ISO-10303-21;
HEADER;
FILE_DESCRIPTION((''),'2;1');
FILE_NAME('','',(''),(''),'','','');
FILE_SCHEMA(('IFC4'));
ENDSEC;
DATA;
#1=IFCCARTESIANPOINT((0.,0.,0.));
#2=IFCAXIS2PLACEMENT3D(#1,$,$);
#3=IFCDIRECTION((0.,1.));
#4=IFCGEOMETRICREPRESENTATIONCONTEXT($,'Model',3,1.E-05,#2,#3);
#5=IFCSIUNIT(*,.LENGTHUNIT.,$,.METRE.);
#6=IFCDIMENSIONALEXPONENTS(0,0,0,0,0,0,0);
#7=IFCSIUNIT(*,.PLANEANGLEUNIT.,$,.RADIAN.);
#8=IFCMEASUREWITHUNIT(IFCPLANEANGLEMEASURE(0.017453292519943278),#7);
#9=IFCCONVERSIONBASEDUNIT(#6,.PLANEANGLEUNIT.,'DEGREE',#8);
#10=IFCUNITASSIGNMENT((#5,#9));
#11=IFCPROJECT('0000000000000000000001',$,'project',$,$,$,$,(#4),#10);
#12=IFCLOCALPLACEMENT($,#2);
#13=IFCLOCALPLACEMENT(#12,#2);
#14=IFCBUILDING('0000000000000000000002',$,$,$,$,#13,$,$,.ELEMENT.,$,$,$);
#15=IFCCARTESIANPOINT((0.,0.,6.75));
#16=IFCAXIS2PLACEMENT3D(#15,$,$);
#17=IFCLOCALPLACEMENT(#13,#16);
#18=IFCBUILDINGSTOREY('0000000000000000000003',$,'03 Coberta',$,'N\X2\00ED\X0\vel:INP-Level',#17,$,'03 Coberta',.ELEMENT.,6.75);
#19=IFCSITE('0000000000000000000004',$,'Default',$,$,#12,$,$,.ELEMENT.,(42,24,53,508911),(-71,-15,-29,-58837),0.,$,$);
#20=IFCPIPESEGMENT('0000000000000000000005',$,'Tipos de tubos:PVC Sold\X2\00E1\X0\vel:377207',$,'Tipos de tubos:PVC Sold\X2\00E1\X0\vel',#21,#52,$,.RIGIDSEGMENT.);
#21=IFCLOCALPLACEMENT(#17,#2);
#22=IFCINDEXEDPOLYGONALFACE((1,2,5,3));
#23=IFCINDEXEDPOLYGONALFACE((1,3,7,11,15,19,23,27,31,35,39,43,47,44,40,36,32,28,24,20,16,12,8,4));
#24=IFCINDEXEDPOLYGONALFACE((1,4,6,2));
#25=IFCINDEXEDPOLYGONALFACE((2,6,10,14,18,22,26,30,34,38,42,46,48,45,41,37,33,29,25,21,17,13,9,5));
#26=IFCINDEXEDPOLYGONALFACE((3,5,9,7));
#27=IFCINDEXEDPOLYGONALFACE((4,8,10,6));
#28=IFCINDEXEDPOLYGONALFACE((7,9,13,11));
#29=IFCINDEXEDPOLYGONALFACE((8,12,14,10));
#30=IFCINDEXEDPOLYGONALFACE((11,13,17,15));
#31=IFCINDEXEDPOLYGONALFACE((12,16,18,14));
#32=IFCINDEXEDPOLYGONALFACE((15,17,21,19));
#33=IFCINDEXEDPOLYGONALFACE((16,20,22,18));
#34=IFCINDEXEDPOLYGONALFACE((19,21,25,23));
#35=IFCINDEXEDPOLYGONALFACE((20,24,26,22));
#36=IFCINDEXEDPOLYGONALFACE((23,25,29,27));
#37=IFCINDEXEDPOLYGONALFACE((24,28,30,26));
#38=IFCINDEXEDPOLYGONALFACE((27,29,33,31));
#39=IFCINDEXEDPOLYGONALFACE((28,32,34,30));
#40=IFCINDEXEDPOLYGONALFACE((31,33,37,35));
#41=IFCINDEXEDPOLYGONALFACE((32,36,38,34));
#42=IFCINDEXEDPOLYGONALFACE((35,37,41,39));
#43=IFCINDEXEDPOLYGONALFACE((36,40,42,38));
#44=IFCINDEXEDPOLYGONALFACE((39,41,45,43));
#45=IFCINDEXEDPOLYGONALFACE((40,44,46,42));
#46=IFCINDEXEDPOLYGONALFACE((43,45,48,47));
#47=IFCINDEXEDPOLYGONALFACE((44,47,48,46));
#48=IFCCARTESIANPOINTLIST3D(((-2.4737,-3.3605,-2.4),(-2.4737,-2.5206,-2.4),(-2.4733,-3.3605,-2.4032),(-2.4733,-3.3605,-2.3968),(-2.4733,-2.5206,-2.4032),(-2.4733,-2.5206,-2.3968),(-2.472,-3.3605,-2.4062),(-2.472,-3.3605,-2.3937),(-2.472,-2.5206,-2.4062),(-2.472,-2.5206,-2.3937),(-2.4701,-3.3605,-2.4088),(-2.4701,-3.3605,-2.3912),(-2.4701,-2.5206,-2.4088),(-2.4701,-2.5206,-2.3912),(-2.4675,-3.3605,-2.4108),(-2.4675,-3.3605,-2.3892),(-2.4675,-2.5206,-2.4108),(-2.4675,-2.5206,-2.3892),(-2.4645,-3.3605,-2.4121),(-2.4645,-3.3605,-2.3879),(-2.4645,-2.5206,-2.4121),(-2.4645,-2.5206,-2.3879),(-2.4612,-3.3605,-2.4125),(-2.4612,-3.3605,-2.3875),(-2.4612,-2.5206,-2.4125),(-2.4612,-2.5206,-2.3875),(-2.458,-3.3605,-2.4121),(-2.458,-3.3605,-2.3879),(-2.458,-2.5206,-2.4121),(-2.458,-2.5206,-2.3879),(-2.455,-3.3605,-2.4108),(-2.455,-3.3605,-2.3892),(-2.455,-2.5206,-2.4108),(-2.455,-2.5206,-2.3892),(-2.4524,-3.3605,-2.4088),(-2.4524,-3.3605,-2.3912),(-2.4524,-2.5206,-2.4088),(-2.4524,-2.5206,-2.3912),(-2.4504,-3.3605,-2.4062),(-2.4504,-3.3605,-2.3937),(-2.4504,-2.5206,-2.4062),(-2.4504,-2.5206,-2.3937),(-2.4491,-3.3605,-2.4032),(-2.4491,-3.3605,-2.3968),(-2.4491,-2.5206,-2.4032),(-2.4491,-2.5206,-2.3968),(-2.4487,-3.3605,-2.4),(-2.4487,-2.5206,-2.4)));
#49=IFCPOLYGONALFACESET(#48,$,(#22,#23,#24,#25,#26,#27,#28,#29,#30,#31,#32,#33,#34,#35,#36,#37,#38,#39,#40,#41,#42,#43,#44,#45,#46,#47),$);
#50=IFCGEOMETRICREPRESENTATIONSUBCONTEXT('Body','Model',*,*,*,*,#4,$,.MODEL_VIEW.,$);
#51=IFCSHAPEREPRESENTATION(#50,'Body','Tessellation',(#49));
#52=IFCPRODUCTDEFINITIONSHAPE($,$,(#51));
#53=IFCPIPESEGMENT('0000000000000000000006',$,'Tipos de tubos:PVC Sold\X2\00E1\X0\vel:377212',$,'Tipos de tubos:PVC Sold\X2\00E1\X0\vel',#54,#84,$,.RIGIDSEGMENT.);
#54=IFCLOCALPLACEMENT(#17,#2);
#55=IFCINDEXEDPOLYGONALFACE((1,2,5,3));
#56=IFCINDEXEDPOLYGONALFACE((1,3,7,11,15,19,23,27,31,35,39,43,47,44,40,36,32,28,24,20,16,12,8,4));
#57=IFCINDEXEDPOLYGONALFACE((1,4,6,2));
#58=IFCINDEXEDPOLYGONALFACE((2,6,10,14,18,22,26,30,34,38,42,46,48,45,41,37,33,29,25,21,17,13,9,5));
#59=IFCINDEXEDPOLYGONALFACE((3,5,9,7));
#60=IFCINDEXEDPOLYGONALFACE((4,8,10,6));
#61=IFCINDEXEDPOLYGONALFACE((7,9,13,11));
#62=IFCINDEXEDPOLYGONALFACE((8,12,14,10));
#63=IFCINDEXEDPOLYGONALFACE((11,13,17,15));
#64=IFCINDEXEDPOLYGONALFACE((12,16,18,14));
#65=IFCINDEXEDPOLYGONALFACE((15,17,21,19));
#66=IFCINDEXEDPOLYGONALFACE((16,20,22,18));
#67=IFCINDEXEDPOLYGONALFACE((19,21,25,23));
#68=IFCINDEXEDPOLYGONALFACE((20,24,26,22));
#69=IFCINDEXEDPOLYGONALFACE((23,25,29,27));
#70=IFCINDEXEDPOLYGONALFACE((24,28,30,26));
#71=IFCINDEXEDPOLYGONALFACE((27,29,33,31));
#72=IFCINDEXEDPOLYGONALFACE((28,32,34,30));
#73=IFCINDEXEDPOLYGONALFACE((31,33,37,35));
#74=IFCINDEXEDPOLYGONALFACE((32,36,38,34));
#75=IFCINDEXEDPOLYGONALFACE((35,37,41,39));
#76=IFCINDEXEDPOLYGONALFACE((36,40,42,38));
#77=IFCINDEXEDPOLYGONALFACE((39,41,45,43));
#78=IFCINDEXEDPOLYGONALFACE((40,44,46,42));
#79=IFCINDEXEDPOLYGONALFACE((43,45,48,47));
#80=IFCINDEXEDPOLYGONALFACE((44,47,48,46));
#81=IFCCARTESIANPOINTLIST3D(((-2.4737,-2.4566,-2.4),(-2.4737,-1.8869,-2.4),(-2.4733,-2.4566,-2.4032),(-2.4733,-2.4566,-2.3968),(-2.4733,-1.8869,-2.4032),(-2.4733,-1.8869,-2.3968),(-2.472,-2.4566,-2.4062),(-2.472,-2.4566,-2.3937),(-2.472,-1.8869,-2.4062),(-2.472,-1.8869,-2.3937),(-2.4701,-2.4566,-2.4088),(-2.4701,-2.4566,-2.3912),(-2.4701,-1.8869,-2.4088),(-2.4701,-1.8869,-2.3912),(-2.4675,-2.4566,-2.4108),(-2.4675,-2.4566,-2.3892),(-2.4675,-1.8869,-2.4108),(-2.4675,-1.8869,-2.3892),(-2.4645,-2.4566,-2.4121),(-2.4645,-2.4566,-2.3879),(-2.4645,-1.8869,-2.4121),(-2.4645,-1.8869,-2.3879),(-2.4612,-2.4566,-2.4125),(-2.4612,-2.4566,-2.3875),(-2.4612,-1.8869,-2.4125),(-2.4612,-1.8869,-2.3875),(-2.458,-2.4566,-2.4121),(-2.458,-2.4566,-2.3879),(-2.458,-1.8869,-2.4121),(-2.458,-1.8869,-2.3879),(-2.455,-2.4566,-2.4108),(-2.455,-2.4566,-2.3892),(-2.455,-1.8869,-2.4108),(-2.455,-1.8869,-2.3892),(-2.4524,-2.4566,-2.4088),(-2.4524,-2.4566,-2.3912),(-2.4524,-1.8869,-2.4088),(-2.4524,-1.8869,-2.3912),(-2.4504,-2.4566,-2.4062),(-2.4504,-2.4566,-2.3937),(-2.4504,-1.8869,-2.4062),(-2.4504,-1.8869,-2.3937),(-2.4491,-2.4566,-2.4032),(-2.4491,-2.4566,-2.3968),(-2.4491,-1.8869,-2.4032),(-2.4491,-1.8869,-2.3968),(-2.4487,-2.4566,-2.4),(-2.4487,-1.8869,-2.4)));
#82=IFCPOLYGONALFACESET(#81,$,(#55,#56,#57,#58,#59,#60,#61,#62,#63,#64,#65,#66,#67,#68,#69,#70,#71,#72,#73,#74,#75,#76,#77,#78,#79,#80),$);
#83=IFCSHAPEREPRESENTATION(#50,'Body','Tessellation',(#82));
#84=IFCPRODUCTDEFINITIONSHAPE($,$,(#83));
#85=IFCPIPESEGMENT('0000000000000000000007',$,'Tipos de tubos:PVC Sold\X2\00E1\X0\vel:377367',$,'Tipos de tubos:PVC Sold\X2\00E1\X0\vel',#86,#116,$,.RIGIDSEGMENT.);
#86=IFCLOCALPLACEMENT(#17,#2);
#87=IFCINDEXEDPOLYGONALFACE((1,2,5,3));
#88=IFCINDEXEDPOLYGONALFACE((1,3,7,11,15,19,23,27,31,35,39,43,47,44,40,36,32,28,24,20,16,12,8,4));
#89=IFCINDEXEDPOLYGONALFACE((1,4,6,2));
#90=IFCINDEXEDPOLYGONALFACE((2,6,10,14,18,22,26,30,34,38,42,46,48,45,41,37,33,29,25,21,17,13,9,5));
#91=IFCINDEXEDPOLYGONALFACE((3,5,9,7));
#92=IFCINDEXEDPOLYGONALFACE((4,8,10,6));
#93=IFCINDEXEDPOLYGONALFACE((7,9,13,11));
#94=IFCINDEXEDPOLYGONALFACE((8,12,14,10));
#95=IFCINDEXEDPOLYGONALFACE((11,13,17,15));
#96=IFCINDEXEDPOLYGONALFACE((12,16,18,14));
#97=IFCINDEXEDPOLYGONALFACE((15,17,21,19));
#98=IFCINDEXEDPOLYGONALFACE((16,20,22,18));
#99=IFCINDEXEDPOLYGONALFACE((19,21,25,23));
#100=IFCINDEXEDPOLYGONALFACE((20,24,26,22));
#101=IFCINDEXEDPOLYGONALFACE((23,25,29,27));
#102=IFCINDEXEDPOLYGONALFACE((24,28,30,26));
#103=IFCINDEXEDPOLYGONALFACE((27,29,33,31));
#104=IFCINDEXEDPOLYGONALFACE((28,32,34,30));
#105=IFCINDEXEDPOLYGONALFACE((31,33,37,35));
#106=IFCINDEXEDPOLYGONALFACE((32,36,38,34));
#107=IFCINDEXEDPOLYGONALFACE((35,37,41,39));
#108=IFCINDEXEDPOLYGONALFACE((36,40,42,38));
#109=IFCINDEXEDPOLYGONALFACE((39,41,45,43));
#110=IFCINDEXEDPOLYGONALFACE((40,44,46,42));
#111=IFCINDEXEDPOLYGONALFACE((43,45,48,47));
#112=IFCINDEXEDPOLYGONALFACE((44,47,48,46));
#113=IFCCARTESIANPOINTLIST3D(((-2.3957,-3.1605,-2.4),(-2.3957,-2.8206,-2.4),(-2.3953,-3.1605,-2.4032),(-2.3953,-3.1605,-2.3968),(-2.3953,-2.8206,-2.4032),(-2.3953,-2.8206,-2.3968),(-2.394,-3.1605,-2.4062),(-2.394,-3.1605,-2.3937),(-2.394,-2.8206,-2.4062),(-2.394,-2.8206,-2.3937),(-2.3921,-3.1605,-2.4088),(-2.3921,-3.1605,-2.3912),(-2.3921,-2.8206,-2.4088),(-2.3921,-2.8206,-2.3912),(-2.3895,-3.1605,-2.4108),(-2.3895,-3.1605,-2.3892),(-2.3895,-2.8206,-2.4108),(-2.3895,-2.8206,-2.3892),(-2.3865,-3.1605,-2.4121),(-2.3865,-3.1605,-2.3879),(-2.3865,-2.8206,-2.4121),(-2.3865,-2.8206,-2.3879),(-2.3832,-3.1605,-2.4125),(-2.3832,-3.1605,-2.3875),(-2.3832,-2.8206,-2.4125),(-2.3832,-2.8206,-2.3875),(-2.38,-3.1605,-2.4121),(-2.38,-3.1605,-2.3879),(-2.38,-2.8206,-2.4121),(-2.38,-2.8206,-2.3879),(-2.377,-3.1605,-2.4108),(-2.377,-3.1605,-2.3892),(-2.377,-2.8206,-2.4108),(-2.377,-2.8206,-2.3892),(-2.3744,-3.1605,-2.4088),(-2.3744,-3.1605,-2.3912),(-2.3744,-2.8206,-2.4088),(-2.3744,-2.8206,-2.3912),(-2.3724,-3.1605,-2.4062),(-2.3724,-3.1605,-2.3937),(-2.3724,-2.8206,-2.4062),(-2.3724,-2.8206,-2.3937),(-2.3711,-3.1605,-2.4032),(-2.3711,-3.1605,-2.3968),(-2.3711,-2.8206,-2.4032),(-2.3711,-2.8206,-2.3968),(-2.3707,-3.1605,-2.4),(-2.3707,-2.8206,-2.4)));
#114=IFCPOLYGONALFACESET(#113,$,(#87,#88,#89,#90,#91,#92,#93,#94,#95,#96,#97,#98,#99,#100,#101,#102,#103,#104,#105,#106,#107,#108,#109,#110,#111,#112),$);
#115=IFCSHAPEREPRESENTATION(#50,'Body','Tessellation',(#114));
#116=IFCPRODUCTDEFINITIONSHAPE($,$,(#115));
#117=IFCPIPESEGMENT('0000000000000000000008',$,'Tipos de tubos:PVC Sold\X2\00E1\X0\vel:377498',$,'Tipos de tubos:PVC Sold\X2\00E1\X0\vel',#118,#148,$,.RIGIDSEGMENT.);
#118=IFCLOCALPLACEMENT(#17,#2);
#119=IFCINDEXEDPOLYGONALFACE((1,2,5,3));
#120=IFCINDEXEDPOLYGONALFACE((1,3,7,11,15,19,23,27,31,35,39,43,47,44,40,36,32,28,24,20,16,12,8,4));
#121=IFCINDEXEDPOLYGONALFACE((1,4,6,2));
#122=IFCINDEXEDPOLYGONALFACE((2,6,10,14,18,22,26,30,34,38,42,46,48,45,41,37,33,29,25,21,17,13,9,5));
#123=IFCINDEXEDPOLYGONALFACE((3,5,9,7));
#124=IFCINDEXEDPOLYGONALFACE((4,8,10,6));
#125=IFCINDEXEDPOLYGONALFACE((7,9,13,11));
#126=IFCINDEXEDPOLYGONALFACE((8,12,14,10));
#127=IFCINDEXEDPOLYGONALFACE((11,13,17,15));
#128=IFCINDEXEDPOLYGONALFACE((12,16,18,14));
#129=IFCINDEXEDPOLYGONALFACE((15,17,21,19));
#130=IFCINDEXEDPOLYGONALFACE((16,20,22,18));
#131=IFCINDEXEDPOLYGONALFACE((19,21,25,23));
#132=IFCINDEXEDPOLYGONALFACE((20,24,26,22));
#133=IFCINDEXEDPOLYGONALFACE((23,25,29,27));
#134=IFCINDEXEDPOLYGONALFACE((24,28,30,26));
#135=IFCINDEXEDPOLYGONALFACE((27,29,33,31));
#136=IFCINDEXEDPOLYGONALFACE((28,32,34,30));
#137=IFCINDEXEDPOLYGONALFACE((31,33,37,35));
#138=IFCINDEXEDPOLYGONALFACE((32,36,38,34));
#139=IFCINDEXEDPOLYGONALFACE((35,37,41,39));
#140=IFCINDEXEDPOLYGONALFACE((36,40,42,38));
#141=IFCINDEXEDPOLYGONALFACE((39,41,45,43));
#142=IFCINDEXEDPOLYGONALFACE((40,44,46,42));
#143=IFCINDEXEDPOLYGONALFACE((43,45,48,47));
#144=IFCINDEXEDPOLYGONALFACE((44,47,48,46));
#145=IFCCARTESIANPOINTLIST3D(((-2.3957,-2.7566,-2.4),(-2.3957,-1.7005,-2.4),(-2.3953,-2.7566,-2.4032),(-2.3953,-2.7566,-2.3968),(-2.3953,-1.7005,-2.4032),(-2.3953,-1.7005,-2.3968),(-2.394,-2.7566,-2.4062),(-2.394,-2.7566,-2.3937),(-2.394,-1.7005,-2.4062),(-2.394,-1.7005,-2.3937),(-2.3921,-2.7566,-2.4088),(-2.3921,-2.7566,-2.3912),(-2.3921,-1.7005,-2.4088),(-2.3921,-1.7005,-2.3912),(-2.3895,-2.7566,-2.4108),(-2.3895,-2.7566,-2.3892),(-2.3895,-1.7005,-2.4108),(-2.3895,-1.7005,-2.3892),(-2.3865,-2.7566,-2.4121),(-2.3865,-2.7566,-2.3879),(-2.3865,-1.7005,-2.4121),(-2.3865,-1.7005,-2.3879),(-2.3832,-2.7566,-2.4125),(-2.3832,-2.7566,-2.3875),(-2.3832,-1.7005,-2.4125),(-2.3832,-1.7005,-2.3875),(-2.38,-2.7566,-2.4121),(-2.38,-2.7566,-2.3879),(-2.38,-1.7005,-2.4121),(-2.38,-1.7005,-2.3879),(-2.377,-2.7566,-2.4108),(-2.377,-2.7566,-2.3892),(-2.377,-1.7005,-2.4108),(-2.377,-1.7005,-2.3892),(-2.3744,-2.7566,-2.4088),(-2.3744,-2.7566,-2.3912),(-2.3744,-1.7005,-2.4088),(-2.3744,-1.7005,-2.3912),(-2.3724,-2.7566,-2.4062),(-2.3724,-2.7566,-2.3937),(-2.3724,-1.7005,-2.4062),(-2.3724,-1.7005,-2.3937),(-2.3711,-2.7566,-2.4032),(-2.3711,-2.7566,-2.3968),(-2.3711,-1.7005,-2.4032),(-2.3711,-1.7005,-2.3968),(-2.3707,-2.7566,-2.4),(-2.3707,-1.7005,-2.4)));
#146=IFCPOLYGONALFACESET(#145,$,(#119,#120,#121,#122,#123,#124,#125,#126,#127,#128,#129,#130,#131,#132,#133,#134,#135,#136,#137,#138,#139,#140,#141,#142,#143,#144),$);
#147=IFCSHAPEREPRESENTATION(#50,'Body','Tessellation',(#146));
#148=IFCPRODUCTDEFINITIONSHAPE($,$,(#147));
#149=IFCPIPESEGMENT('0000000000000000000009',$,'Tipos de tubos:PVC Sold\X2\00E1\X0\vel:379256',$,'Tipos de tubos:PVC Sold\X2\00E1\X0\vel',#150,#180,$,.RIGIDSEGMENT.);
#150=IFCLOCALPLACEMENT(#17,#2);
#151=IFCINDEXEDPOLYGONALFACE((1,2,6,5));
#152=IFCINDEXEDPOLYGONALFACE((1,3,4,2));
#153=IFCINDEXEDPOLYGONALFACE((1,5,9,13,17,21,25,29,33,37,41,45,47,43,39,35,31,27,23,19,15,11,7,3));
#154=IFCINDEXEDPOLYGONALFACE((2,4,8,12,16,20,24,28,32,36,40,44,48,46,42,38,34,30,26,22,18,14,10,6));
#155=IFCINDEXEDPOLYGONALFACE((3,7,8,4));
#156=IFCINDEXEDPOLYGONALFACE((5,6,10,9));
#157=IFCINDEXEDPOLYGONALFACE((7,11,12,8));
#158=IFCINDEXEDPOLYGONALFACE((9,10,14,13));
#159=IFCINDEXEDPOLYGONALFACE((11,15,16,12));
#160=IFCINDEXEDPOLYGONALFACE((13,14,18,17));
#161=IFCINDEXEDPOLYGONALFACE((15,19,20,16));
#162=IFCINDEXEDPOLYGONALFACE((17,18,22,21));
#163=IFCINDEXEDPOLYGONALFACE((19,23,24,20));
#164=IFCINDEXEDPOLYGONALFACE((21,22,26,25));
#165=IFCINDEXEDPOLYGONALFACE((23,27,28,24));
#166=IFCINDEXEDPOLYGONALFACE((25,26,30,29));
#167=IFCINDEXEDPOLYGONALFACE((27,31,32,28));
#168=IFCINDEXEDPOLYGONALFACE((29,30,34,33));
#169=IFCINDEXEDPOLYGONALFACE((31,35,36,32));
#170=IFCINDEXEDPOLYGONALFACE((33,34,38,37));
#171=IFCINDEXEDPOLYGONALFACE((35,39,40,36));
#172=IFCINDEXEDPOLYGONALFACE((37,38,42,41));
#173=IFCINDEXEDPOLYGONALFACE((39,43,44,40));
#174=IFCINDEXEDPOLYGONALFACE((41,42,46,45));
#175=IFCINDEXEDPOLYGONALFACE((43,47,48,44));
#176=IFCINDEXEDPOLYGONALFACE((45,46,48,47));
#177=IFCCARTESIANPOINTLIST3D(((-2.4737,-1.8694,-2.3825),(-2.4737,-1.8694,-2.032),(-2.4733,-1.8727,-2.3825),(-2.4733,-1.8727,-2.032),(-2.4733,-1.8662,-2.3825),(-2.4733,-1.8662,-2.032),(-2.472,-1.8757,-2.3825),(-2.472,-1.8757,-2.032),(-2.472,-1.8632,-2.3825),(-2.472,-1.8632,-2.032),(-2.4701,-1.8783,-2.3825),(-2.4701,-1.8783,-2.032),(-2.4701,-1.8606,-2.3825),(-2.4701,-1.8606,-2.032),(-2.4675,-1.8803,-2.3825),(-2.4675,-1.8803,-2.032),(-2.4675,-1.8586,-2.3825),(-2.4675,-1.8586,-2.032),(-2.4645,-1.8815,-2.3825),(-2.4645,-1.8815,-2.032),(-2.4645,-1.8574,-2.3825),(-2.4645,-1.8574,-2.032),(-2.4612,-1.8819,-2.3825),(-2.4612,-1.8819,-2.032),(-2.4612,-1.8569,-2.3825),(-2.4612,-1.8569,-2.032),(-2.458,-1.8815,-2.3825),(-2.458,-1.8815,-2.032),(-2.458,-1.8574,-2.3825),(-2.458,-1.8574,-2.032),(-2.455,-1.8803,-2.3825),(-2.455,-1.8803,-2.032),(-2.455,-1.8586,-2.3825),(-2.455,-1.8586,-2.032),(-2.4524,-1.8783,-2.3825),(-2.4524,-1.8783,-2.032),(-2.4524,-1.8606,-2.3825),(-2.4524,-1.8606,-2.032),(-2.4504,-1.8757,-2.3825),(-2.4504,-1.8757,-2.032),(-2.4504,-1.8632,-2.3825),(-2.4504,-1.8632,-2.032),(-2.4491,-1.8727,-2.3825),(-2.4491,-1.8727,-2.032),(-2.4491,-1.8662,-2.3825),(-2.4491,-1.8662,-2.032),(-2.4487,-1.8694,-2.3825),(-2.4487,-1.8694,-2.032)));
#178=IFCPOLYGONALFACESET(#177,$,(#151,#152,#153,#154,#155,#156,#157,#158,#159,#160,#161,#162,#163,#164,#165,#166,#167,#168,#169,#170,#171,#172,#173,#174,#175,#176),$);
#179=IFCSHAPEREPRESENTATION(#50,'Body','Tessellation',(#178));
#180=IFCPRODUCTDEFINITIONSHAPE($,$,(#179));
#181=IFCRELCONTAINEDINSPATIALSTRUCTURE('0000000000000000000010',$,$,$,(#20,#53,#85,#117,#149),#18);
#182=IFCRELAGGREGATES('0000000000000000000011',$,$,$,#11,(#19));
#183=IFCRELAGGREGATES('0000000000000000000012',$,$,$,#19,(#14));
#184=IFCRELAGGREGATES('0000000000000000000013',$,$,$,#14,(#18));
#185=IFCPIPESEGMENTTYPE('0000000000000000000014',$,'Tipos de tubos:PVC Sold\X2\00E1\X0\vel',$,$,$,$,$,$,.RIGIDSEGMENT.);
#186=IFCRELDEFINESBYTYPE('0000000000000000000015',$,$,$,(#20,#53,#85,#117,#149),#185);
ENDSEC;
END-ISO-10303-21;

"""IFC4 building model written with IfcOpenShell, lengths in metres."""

from ifc_helpers import new_model, entity, si_unit, converted_unit, direction, frame, origin, place, context, subcontext, project, spatial, arc, indexed_curve, outline, extrude, type_object, element, save


model = new_model("IFC4")

# Units and contexts
model_context = context("Model", 3, precision=1e-05, world=origin(), true_north=direction((0.0, 1.0)))
body_context = subcontext(model_context, "Body", "Model", "MODEL_VIEW")
ifc_project = project(units=[si_unit("LENGTHUNIT", "METRE"), converted_unit("PLANEANGLEUNIT", "DEGREE", entity("IfcPlaneAngleMeasure", 0.017453292519943278), si_unit("PLANEANGLEUNIT", "RADIAN"), dimensions=[0, 0, 0, 0, 0, 0, 0])], contexts=[model_context])

# Site, building, storey
site_placement = place(None, origin())
site = spatial("IfcSite", under=ifc_project, at=site_placement, Name="Default", CompositionType="ELEMENT", RefLatitude=(42, 24, 53, 508911), RefLongitude=(-71, -15, -29, -58837), RefElevation=0.0)
building_placement = place(site_placement, origin())
building = spatial("IfcBuilding", under=site, at=building_placement, CompositionType="ELEMENT")
storey_placement = place(building_placement, frame((0.0, 0.0, 6.75)))
storey = spatial("IfcBuildingStorey", under=building, at=storey_placement, Name="03 Coberta", ObjectType="Nível:INP-Level", LongName="03 Coberta", CompositionType="ELEMENT", Elevation=6.75)

# Pipe segments
pipe_segment_type = type_object("IfcPipeSegmentType", Name="Tipos de tubos:PVC Soldável", PredefinedType="RIGIDSEGMENT")
pipe_segment_1_placement = place(storey_placement, origin())
element("IfcPipeSegment", 1, at=pipe_segment_1_placement, inside=storey, type_object=pipe_segment_type, Name="Tipos de tubos:PVC Soldável:377207", ObjectType="Tipos de tubos:PVC Soldável", PredefinedType="RIGIDSEGMENT", context=body_context, shape_type="SweptSolid", body=[
    extrude(outline(indexed_curve([(0.0125, 0.0), (0.0088, 0.0088), (0.0, 0.0125), (-0.0088, 0.0088), (-0.0125, 0.0), (-0.0088, -0.0088), (0.0, -0.0125), (0.0088, -0.0088)], segments=[arc(1, 2, 3), arc(3, 4, 5), arc(5, 6, 7), arc(7, 8, 1)], self_intersect=False)), frame((-2.4612, -3.3605, -2.4), z_axis=(0.0, 1.0, 0.0), x_axis=(-1.0, 0.0, 0.0)), (0.0, 0.0, 1.0), 0.8398),
])
pipe_segment_2_placement = place(storey_placement, origin())
element("IfcPipeSegment", 2, at=pipe_segment_2_placement, inside=storey, type_object=pipe_segment_type, Name="Tipos de tubos:PVC Soldável:377212", ObjectType="Tipos de tubos:PVC Soldável", PredefinedType="RIGIDSEGMENT", context=body_context, shape_type="SweptSolid", body=[
    extrude(outline(indexed_curve([(0.0125, 0.0), (0.0088, 0.0088), (0.0, 0.0125), (-0.0088, 0.0088), (-0.0125, 0.0), (-0.0088, -0.0088), (0.0, -0.0125), (0.0088, -0.0088)], segments=[arc(1, 2, 3), arc(3, 4, 5), arc(5, 6, 7), arc(7, 8, 1)], self_intersect=False)), frame((-2.4612, -2.4566, -2.4), z_axis=(0.0, 1.0, 0.0), x_axis=(1.0, 0.0, 0.0)), (0.0, 0.0, 1.0), 0.5697),
])
pipe_segment_3_placement = place(storey_placement, origin())
element("IfcPipeSegment", 3, at=pipe_segment_3_placement, inside=storey, type_object=pipe_segment_type, Name="Tipos de tubos:PVC Soldável:377367", ObjectType="Tipos de tubos:PVC Soldável", PredefinedType="RIGIDSEGMENT", context=body_context, shape_type="SweptSolid", body=[
    extrude(outline(indexed_curve([(0.0125, 0.0), (0.0088, 0.0088), (0.0, 0.0125), (-0.0088, 0.0088), (-0.0125, 0.0), (-0.0088, -0.0088), (0.0, -0.0125), (0.0088, -0.0088)], segments=[arc(1, 2, 3), arc(3, 4, 5), arc(5, 6, 7), arc(7, 8, 1)], self_intersect=False)), frame((-2.3832, -3.1605, -2.4), z_axis=(0.0, 1.0, 0.0), x_axis=(-1.0, 0.0, 0.0)), (0.0, 0.0, 1.0), 0.3398),
])
pipe_segment_4_placement = place(storey_placement, origin())
element("IfcPipeSegment", 4, at=pipe_segment_4_placement, inside=storey, type_object=pipe_segment_type, Name="Tipos de tubos:PVC Soldável:377498", ObjectType="Tipos de tubos:PVC Soldável", PredefinedType="RIGIDSEGMENT", context=body_context, shape_type="SweptSolid", body=[
    extrude(outline(indexed_curve([(0.0125, 0.0), (0.0088, 0.0088), (0.0, 0.0125), (-0.0088, 0.0088), (-0.0125, 0.0), (-0.0088, -0.0088), (0.0, -0.0125), (0.0088, -0.0088)], segments=[arc(1, 2, 3), arc(3, 4, 5), arc(5, 6, 7), arc(7, 8, 1)], self_intersect=False)), frame((-2.3832, -2.7566, -2.4), z_axis=(0.0, 1.0, 0.0), x_axis=(-1.0, 0.0, 0.0)), (0.0, 0.0, 1.0), 1.0561),
])
pipe_segment_5_placement = place(storey_placement, origin())
element("IfcPipeSegment", 5, at=pipe_segment_5_placement, inside=storey, type_object=pipe_segment_type, Name="Tipos de tubos:PVC Soldável:379256", ObjectType="Tipos de tubos:PVC Soldável", PredefinedType="RIGIDSEGMENT", context=body_context, shape_type="SweptSolid", body=[
    extrude(outline(indexed_curve([(0.0125, 0.0), (0.0088, 0.0088), (0.0, 0.0125), (-0.0088, 0.0088), (-0.0125, 0.0), (-0.0088, -0.0088), (0.0, -0.0125), (0.0088, -0.0088)], segments=[arc(1, 2, 3), arc(3, 4, 5), arc(5, 6, 7), arc(7, 8, 1)], self_intersect=False)), frame((-2.4612, -1.8694, -2.3825)), (0.0, 0.0, 1.0), 0.3505),
])

save(model, "model.ifc")
